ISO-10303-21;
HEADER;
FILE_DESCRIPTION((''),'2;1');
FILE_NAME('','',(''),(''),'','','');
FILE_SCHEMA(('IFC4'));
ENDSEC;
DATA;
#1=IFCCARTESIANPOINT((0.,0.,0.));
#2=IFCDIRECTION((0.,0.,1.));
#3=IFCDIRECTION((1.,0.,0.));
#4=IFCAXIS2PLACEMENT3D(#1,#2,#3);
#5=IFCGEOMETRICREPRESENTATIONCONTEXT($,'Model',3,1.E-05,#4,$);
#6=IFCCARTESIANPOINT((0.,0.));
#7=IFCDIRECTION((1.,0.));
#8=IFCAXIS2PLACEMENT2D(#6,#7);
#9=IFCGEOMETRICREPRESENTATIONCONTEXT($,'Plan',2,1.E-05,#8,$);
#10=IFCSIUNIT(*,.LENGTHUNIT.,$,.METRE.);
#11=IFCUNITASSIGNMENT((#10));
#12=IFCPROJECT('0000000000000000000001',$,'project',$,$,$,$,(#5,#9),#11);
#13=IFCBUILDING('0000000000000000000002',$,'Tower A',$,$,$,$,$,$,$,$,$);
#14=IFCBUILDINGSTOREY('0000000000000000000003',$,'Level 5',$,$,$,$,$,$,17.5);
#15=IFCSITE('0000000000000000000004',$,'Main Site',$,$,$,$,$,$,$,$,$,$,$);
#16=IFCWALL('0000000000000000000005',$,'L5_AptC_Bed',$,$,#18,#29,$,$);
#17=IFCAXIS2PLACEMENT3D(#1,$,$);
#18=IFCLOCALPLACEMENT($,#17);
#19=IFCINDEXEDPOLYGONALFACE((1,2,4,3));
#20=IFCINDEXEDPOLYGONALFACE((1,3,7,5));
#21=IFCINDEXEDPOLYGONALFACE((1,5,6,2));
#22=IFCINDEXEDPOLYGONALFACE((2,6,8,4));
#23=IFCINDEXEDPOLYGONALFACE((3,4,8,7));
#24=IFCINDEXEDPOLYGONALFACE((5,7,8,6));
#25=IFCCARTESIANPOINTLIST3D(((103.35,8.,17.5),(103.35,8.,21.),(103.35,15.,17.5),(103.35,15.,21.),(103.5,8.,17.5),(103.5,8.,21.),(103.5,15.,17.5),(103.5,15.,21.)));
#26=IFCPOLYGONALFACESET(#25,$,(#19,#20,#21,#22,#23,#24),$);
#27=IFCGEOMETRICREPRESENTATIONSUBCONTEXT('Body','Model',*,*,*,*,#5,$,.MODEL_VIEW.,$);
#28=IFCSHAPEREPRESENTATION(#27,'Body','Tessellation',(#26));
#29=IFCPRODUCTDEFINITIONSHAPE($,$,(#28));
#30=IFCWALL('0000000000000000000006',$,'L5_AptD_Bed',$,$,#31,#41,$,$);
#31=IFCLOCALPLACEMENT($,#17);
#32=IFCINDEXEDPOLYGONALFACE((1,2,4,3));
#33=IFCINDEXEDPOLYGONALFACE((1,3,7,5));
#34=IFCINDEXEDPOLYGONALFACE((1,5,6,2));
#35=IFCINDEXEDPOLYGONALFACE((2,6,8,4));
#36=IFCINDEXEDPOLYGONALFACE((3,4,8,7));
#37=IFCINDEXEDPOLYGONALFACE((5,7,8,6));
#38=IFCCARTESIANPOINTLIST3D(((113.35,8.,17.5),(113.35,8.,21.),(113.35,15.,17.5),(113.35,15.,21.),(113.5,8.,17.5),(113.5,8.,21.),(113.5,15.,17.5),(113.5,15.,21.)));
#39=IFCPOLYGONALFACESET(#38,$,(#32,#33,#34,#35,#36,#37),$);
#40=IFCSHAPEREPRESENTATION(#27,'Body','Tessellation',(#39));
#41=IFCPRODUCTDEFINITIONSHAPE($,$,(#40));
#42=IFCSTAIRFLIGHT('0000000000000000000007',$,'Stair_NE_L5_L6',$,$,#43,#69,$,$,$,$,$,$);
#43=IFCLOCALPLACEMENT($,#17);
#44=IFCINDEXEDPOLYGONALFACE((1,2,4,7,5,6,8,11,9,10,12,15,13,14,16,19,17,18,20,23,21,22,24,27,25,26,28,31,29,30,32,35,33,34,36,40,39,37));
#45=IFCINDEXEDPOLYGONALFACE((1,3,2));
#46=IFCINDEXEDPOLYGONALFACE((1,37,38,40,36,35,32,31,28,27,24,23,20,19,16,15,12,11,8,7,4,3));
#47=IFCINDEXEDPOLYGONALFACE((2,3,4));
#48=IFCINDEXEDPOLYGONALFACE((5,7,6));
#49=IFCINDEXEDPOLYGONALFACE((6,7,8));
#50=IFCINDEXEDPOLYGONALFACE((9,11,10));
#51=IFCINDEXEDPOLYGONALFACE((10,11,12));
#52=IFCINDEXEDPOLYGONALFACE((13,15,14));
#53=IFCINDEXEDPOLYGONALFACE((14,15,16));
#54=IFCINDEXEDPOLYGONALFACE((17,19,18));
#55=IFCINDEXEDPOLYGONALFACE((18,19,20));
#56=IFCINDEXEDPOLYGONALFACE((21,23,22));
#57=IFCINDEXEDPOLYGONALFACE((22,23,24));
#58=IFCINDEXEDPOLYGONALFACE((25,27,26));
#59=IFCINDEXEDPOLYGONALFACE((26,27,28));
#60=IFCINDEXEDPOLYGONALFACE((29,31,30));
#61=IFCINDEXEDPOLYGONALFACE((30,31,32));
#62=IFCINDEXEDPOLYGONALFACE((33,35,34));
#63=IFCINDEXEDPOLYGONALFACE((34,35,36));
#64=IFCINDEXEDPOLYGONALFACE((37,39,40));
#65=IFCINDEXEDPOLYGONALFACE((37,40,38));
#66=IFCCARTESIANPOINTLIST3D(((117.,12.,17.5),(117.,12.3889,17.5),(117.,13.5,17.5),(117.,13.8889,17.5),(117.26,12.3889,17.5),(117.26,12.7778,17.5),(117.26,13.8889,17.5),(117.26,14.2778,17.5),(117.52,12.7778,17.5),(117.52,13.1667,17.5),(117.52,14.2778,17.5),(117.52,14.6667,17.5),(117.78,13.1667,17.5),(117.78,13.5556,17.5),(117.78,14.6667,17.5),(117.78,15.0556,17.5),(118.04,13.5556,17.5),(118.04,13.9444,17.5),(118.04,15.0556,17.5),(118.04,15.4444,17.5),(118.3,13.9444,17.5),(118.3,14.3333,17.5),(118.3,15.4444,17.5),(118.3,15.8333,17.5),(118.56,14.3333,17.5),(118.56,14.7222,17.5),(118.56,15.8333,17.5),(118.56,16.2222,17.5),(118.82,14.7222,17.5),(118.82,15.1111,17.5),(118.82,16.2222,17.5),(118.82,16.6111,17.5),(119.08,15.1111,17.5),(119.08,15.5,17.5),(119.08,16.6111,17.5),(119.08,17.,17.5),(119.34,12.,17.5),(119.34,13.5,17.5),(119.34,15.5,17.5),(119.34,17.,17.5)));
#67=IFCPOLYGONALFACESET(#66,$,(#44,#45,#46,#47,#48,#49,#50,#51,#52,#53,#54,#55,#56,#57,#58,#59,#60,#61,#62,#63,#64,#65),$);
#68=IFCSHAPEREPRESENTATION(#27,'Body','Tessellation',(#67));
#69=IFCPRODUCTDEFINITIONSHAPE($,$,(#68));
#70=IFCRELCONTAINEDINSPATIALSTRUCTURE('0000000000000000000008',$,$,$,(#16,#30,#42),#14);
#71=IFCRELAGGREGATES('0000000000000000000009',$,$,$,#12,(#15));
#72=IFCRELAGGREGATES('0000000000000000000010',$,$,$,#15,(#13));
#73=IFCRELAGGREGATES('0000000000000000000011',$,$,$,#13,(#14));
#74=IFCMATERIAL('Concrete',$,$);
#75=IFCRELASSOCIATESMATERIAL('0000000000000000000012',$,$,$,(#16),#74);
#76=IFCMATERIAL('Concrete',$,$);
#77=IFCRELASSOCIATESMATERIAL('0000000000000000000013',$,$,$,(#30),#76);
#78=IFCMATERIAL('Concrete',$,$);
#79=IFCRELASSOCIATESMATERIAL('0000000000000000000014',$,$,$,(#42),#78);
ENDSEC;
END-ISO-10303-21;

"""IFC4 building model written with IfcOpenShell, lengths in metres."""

from ifc_helpers import new_model, si_unit, frame, origin_with_axes, origin_2d_with_axis, place, context, subcontext, project, spatial, line, indexed_curve, outline, extrude, material, element, save


model = new_model("IFC4")

# Units and contexts
model_context = context("Model", 3, precision=1e-05, world=origin_with_axes())
plan_context = context("Plan", 2, precision=1e-05, world=origin_2d_with_axis())
body_context = subcontext(model_context, "Body", "Model", "MODEL_VIEW")
ifc_project = project(units=[si_unit("LENGTHUNIT", "METRE")], contexts=[model_context, plan_context])

# Site, building, storey
site = spatial("IfcSite", under=ifc_project, Name="Main Site")
building = spatial("IfcBuilding", under=site, Name="Tower A")
storey = spatial("IfcBuildingStorey", under=building, Name="Level 5", Elevation=17.5)

# Walls
ifc_material_1 = material(Name="Concrete")
wall_1_placement = place(None, frame((103.5, 8.0, 17.5), z_axis=(0.0, 0.0, 1.0), x_axis=(0.0, 1.0, 0.0)))
element("IfcWall", 1, at=wall_1_placement, inside=storey, material=ifc_material_1, Name="L5_AptC_Bed", context=body_context, shape_type="SweptSolid", body=[
    extrude(outline(indexed_curve([(0.0, 0.0), (0.0, 0.15), (7.0, 0.15), (7.0, 0.0), (0.0, 0.0)], self_intersect=False)), origin_with_axes(), (0.0, 0.0, 1.0), 3.5),
])
ifc_material_2 = material(Name="Concrete")
wall_2_placement = place(None, frame((113.5, 8.0, 17.5), z_axis=(0.0, 0.0, 1.0), x_axis=(0.0, 1.0, 0.0)))
element("IfcWall", 2, at=wall_2_placement, inside=storey, material=ifc_material_2, Name="L5_AptD_Bed", context=body_context, shape_type="SweptSolid", body=[
    extrude(outline(indexed_curve([(0.0, 0.0), (0.0, 0.15), (7.0, 0.15), (7.0, 0.0), (0.0, 0.0)], self_intersect=False)), origin_with_axes(), (0.0, 0.0, 1.0), 3.5),
])

# Stair flight
ifc_material_3 = material(Name="Concrete")
stair_flight_placement = place(None, frame((117.0, 12.0, 17.5), z_axis=(0.0, 0.0, 1.0), x_axis=(1.0, 0.0, 0.0)))
element("IfcStairFlight", 3, at=stair_flight_placement, inside=storey, material=ifc_material_3, Name="Stair_NE_L5_L6", context=body_context, shape_type="SweptSolid", body=[
    extrude(outline(indexed_curve([(0.0, 0.0), (0.0, 0.3889), (0.26, 0.3889), (0.26, 0.7778), (0.52, 0.7778), (0.52, 1.1667), (0.78, 1.1667), (0.78, 1.5556), (1.04, 1.5556), (1.04, 1.9444), (1.3, 1.9444), (1.3, 2.3333), (1.56, 2.3333), (1.56, 2.7222), (1.82, 2.7222), (1.82, 3.1111), (2.08, 3.1111), (2.08, 3.5), (2.34, 3.5), (2.34, 0.0)], segments=[line(1, 2, 3, 4, 5, 6, 7, 8, 9, 10, 11, 12, 13, 14, 15, 16, 17, 18, 19, 20, 1)])), origin_with_axes(), (0.0, 1.0, 0.0), 1.5),
])

save(model, "model.ifc")
